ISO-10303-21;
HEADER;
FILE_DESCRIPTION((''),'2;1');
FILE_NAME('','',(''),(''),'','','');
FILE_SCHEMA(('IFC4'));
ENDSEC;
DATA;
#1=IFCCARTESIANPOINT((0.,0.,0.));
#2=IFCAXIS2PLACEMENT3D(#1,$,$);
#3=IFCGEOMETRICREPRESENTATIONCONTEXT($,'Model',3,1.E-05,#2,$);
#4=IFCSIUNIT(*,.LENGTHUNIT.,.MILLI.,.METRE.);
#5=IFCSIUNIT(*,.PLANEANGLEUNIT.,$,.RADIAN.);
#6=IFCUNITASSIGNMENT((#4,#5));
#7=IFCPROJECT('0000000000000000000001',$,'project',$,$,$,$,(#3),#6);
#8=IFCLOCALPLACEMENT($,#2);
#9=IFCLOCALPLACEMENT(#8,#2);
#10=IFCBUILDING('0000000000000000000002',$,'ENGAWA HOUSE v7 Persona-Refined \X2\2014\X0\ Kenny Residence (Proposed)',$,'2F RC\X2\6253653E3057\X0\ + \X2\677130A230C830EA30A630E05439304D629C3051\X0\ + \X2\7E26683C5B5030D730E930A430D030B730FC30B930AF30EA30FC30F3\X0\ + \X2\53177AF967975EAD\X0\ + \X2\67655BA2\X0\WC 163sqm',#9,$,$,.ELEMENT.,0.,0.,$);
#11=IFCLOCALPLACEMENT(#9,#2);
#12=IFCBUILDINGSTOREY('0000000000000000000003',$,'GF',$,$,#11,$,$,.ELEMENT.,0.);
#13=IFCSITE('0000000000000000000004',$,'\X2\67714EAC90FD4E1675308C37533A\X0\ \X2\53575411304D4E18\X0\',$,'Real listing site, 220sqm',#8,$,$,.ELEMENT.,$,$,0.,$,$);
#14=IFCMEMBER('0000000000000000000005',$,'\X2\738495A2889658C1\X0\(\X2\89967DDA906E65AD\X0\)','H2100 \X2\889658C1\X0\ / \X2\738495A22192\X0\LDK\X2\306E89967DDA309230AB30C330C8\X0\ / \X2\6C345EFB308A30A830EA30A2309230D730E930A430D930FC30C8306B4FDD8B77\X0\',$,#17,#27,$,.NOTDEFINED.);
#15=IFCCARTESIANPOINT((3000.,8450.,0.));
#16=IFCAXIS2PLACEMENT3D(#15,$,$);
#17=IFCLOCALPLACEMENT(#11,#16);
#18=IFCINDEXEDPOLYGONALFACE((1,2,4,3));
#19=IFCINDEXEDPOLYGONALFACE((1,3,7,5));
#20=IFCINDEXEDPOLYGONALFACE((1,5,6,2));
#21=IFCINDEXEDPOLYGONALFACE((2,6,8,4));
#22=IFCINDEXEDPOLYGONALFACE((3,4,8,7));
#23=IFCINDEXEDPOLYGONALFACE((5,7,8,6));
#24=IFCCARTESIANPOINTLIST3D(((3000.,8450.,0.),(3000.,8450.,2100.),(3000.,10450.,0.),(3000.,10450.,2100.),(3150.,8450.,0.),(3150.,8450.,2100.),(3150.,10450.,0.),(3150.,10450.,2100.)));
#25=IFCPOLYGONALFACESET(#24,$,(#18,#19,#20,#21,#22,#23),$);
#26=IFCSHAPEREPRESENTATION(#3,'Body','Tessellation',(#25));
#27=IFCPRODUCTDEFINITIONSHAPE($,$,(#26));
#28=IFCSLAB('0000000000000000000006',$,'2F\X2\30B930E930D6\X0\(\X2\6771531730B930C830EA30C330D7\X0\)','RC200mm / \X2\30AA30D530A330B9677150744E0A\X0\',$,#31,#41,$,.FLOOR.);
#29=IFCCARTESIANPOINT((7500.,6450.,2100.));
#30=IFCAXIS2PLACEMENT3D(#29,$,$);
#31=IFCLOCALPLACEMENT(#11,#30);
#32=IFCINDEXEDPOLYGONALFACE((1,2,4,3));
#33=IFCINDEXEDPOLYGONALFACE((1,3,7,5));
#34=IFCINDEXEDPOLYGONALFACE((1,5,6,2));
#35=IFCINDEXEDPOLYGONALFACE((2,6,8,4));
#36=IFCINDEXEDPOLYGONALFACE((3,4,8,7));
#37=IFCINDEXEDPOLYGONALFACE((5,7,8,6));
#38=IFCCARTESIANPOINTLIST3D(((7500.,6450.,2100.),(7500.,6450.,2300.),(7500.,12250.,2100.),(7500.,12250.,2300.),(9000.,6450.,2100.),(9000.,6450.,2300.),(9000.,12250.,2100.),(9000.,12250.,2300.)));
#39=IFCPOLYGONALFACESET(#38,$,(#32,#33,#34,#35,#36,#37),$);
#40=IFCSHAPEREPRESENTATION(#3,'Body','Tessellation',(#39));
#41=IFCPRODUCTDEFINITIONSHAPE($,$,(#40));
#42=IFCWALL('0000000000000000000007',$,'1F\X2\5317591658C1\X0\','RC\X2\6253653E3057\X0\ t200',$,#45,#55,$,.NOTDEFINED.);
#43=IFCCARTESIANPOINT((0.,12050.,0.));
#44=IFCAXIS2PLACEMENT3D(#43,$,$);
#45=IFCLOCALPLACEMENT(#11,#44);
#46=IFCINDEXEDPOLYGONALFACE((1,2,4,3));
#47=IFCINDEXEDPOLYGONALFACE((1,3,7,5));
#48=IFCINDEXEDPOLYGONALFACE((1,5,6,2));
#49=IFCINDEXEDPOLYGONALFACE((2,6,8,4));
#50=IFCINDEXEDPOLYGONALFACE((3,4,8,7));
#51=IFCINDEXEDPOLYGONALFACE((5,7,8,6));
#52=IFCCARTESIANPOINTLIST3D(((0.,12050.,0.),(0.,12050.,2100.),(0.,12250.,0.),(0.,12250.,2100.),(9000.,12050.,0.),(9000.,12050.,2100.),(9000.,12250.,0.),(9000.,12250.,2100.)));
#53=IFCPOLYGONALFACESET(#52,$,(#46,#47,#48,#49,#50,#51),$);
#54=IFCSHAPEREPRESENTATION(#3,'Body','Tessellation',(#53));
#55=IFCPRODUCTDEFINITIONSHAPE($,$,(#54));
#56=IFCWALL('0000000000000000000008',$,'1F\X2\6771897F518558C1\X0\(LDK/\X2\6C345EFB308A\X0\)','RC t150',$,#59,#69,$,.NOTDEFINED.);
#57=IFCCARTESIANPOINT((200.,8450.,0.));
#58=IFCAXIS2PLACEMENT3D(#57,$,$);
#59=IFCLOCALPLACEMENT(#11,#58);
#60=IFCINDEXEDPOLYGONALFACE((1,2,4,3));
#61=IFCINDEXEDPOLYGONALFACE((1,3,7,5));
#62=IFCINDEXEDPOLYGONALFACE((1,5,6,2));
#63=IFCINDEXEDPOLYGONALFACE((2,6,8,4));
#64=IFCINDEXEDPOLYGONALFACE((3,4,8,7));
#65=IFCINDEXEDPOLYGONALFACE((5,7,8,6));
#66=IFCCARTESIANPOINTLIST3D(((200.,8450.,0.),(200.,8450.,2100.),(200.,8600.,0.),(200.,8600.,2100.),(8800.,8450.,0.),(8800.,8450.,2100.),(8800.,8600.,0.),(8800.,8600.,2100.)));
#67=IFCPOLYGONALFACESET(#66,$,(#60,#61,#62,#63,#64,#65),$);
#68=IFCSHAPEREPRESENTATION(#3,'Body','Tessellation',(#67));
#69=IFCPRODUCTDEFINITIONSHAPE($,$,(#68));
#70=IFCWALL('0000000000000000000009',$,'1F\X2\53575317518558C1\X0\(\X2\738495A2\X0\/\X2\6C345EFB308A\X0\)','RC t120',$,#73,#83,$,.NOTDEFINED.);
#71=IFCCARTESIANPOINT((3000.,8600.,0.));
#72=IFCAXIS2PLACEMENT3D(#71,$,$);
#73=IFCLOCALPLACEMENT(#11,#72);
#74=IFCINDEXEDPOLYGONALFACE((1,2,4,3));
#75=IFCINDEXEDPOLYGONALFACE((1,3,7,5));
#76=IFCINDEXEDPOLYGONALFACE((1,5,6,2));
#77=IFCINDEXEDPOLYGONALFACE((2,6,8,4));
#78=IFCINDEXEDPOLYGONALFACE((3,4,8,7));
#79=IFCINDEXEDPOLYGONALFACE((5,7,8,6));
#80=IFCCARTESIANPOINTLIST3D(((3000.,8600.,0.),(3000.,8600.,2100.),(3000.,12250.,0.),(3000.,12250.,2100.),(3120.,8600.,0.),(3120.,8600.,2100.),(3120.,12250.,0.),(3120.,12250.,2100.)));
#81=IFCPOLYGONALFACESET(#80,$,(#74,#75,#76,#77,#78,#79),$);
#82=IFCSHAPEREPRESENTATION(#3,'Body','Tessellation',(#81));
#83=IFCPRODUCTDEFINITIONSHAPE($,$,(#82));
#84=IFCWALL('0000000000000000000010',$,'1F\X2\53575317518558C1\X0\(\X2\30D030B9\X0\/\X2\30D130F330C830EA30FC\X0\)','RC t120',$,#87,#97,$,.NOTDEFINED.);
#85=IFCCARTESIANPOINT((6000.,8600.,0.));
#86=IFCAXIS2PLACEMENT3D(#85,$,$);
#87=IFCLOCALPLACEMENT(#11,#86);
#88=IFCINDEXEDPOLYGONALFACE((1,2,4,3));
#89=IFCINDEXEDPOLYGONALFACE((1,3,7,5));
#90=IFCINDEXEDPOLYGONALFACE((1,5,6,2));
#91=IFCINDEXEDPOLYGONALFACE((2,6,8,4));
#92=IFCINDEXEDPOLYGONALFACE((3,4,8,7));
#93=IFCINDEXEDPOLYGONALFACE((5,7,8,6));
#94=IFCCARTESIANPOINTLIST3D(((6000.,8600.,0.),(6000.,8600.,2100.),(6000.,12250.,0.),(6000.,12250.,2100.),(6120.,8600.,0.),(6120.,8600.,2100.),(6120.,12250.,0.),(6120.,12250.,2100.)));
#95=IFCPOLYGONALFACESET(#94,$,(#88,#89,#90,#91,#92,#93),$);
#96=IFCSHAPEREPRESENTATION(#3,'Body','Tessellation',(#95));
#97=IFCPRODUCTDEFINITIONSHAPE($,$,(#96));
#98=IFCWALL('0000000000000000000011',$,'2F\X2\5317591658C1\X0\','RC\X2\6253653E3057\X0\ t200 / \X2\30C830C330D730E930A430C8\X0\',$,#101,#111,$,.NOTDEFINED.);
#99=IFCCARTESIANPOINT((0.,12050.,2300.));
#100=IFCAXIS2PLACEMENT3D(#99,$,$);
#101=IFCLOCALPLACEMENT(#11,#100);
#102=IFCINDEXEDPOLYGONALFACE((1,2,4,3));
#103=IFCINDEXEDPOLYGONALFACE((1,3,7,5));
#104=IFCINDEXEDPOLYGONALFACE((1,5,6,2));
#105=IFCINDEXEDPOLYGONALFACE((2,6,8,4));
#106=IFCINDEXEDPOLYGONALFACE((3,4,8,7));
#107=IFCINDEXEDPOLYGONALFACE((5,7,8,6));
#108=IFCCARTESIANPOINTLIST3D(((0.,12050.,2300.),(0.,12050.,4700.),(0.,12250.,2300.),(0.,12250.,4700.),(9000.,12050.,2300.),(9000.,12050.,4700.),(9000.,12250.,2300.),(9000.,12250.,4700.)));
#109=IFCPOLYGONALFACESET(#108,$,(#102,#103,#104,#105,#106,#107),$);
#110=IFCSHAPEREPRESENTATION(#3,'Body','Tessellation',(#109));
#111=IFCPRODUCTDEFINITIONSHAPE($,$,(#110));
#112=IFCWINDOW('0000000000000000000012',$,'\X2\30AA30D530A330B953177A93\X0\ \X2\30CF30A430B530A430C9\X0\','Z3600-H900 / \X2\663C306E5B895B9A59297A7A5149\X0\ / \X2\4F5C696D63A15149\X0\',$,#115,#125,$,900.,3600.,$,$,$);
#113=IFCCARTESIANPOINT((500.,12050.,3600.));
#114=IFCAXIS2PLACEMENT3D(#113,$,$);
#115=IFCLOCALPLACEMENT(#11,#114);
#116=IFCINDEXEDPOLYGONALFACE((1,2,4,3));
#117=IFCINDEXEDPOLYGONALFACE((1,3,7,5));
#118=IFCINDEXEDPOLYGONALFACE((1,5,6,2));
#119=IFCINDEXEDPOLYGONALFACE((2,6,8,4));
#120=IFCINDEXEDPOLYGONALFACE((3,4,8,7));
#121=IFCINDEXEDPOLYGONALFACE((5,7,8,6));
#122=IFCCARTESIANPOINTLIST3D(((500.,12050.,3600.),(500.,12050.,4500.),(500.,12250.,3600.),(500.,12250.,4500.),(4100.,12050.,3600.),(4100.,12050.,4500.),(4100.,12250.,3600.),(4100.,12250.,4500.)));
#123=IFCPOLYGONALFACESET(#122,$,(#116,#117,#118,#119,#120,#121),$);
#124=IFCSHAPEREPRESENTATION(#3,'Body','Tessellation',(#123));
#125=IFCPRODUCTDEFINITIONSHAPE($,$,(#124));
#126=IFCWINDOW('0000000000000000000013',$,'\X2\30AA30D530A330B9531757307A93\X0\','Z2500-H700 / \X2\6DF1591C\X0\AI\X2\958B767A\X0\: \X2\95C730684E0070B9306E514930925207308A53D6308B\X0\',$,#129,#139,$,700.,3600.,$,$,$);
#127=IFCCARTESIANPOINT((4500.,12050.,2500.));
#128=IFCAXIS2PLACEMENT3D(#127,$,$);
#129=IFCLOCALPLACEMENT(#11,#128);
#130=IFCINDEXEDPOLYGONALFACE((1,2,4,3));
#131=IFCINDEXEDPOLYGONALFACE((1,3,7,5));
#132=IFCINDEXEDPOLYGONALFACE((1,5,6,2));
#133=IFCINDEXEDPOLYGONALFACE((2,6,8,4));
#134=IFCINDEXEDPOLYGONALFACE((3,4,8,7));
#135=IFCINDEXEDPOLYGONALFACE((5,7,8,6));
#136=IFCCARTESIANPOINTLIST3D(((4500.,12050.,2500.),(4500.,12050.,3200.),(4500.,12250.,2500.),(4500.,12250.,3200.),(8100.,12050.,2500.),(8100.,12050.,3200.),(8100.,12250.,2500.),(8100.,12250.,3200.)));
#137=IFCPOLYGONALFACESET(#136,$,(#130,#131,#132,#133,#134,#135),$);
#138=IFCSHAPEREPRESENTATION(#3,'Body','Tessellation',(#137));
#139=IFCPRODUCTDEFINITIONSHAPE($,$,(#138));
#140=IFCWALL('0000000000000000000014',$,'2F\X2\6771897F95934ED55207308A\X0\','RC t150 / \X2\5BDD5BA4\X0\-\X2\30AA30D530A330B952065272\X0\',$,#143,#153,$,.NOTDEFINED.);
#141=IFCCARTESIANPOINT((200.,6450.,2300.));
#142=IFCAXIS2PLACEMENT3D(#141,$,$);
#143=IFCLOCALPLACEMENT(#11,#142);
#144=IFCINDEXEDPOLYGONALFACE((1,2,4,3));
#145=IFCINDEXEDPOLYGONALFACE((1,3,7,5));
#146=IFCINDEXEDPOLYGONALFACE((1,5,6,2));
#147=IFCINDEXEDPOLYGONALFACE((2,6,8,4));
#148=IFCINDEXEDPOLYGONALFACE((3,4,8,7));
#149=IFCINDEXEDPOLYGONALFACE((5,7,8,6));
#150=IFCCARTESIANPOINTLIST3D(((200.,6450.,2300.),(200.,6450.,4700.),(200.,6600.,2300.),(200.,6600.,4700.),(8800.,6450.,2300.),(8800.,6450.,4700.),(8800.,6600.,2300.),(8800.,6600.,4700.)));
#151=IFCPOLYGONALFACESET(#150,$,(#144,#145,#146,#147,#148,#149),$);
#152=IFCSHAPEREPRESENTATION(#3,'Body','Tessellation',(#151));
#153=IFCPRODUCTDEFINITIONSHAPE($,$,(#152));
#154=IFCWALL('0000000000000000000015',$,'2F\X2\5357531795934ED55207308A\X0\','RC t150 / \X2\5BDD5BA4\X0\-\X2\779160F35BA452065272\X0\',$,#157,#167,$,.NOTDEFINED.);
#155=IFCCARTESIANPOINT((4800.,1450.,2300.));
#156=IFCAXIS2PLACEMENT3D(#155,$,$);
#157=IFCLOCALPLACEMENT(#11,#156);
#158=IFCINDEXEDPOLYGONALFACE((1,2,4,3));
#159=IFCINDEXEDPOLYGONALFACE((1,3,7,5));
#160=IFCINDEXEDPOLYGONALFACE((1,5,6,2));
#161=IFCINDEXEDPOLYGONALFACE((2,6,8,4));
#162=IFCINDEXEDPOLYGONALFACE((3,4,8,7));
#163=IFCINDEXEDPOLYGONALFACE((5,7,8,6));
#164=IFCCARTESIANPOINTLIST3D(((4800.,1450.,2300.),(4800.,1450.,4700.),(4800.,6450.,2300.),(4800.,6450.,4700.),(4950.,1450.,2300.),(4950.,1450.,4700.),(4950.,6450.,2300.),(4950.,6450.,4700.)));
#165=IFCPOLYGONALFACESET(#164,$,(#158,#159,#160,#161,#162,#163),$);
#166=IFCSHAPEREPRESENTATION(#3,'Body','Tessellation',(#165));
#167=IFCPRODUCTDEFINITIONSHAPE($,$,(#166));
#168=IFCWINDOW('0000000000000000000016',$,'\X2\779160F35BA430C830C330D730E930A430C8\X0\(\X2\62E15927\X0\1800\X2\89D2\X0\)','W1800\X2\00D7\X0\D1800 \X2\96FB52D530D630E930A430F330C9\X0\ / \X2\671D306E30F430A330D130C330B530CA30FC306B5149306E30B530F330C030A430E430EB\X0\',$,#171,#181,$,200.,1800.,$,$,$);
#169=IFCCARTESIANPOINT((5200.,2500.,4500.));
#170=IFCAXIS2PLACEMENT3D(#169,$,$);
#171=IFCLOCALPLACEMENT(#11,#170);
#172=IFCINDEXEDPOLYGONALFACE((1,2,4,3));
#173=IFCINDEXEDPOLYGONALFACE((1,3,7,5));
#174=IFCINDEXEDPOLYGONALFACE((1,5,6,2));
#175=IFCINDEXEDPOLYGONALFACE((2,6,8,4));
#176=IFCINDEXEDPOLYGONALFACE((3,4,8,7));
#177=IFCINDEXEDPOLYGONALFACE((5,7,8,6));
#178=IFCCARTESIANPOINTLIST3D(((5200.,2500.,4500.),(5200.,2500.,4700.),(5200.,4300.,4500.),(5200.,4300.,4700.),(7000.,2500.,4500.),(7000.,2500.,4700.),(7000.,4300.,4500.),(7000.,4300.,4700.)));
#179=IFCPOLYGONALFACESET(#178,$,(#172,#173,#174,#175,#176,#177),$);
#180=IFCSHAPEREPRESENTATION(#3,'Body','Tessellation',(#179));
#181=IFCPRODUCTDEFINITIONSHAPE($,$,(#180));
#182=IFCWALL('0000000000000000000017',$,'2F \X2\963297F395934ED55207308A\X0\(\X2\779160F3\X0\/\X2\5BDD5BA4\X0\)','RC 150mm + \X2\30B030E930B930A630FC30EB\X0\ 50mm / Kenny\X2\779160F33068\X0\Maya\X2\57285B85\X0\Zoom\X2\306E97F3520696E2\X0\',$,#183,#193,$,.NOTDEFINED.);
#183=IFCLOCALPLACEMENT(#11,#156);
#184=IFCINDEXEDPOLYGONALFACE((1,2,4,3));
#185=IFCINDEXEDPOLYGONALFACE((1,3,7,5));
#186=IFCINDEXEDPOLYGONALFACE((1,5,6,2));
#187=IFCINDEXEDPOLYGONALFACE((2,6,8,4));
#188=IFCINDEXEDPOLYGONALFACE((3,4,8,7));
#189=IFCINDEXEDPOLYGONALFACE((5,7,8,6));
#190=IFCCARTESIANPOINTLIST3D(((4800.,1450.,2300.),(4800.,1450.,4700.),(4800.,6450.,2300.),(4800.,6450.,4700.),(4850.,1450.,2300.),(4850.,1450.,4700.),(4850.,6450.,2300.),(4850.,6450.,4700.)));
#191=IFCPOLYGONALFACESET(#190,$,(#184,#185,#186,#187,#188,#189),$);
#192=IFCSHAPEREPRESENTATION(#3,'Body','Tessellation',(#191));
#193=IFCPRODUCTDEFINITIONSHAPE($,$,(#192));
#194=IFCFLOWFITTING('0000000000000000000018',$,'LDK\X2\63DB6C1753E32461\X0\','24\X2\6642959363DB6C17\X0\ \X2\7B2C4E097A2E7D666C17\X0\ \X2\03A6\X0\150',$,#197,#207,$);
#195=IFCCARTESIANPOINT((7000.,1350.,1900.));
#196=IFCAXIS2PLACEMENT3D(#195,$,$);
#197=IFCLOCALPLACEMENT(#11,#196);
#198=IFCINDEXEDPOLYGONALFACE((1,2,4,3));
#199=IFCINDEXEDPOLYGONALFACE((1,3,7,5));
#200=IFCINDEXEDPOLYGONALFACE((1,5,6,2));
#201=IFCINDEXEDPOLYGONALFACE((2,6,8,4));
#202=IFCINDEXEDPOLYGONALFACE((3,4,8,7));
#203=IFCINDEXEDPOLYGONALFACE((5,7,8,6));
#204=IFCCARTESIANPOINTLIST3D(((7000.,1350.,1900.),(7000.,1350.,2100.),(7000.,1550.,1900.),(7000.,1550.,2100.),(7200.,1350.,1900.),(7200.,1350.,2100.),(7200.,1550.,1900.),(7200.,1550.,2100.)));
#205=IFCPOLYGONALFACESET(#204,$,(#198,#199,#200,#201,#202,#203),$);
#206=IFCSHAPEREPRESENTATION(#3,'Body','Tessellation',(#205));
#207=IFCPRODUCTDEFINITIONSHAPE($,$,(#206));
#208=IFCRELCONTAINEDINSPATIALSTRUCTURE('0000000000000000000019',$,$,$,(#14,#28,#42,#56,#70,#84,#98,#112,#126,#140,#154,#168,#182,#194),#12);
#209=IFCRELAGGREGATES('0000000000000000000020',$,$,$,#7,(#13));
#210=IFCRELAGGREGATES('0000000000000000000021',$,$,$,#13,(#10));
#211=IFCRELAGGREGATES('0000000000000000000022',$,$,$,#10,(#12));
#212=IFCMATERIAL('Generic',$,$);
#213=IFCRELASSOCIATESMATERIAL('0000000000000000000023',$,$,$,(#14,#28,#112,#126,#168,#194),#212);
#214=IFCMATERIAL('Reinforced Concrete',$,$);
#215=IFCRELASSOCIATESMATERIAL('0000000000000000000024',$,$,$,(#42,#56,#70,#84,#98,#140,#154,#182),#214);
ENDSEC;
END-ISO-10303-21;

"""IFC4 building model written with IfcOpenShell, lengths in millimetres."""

from ifc_helpers import new_model, si_unit, frame, frame_2d, origin, place, context, project, spatial, rectangle, extrude, material, element, fill, save


model = new_model("IFC4")

# Units and contexts
model_context = context("Model", 3, precision=1e-05, world=origin())
ifc_project = project(units=[si_unit("LENGTHUNIT", "METRE", prefix="MILLI"), si_unit("PLANEANGLEUNIT", "RADIAN")], contexts=[model_context])

# Site, building, storey
site_placement = place(None, origin())
site = spatial("IfcSite", under=ifc_project, at=site_placement, Name="東京都世田谷区 南向き丘", ObjectType="Real listing site, 220sqm", CompositionType="ELEMENT", RefElevation=0.0)
building_placement = place(site_placement, origin())
building = spatial("IfcBuilding", under=site, at=building_placement, Name="ENGAWA HOUSE v7 Persona-Refined — Kenny Residence (Proposed)", ObjectType="2F RC打放し + 東アトリウム吹き抜け + 縦格子プライバシースクリーン + 北竹林庭 + 来客WC 163sqm", CompositionType="ELEMENT", ElevationOfRefHeight=0.0, ElevationOfTerrain=0.0)
storey_placement = place(building_placement, origin())
storey = spatial("IfcBuildingStorey", under=building, at=storey_placement, Name="GF", CompositionType="ELEMENT", Elevation=0.0)

# Member
ifc_material_1 = material(Name="Generic")
member_placement = place(storey_placement, frame((3000.0, 8450.0, 0.0)))
element("IfcMember", 1, at=member_placement, inside=storey, material=ifc_material_1, Name="玄関袖壁(視線遮断)", Description="H2100 袖壁 / 玄関→LDKの視線をカット / 水廻りエリアをプライベートに保護", PredefinedType="NOTDEFINED", context=model_context, shape_type="SweptSolid", body=[
    extrude(rectangle(XDim=150.0, YDim=2000.0, at=frame_2d((75.0, 1000.0))), frame((3000.0, 8450.0, 0.0)), (0.0, 0.0, 1.0), 2100.0),
])

# Slab
slab_placement = place(storey_placement, frame((7500.0, 6450.0, 2100.0)))
element("IfcSlab", 2, at=slab_placement, inside=storey, material=ifc_material_1, Name="2Fスラブ(東北ストリップ)", Description="RC200mm / オフィス東側上", PredefinedType="FLOOR", context=model_context, shape_type="SweptSolid", body=[
    extrude(rectangle(XDim=1500.0, YDim=5800.0, at=frame_2d((750.0, 2900.0))), frame((7500.0, 6450.0, 2100.0)), (0.0, 0.0, 1.0), 200.0),
])

# Walls
ifc_material_2 = material(Name="Reinforced Concrete")
wall_1_placement = place(storey_placement, frame((0.0, 12050.0, 0.0)))
element("IfcWall", 3, at=wall_1_placement, inside=storey, material=ifc_material_2, Name="1F北外壁", Description="RC打放し t200", PredefinedType="NOTDEFINED", context=model_context, shape_type="SweptSolid", body=[
    extrude(rectangle(XDim=9000.0, YDim=200.0, at=frame_2d((4500.0, 100.0))), frame((0.0, 12050.0, 0.0)), (0.0, 0.0, 1.0), 2100.0),
])
wall_2_placement = place(storey_placement, frame((200.0, 8450.0, 0.0)))
element("IfcWall", 4, at=wall_2_placement, inside=storey, material=ifc_material_2, Name="1F東西内壁(LDK/水廻り)", Description="RC t150", PredefinedType="NOTDEFINED", context=model_context, shape_type="SweptSolid", body=[
    extrude(rectangle(XDim=8600.0, YDim=150.0, at=frame_2d((4300.0, 75.0))), frame((200.0, 8450.0, 0.0)), (0.0, 0.0, 1.0), 2100.0),
])
wall_3_placement = place(storey_placement, frame((3000.0, 8600.0, 0.0)))
element("IfcWall", 5, at=wall_3_placement, inside=storey, material=ifc_material_2, Name="1F南北内壁(玄関/水廻り)", Description="RC t120", PredefinedType="NOTDEFINED", context=model_context, shape_type="SweptSolid", body=[
    extrude(rectangle(XDim=120.0, YDim=3650.0, at=frame_2d((60.0, 1825.0))), frame((3000.0, 8600.0, 0.0)), (0.0, 0.0, 1.0), 2100.0),
])
wall_4_placement = place(storey_placement, frame((6000.0, 8600.0, 0.0)))
element("IfcWall", 6, at=wall_4_placement, inside=storey, material=ifc_material_2, Name="1F南北内壁(バス/パントリー)", Description="RC t120", PredefinedType="NOTDEFINED", context=model_context, shape_type="SweptSolid", body=[
    extrude(rectangle(XDim=120.0, YDim=3650.0, at=frame_2d((60.0, 1825.0))), frame((6000.0, 8600.0, 0.0)), (0.0, 0.0, 1.0), 2100.0),
])

# Wall, openings, windows
wall_5_placement = place(storey_placement, frame((0.0, 12050.0, 2300.0)))
wall_5 = element("IfcWall", 7, at=wall_5_placement, inside=storey, material=ifc_material_2, Name="2F北外壁", Description="RC打放し t200 / トップライト", PredefinedType="NOTDEFINED", context=model_context, shape_type="SweptSolid", body=[
    extrude(rectangle(XDim=9000.0, YDim=200.0, at=frame_2d((4500.0, 100.0))), frame((0.0, 12050.0, 2300.0)), (0.0, 0.0, 1.0), 2400.0),
])
opening_1_placement = place(storey_placement, frame((500.0, 12050.0, 3600.0)))
opening_1 = element("IfcOpeningElement", 8, at=opening_1_placement, cuts=wall_5, PredefinedType="NOTDEFINED", context=model_context, shape_type="SweptSolid", body=[
    extrude(rectangle(XDim=3600.0, YDim=200.0, at=frame_2d((1800.0, 100.0))), frame((500.0, 12050.0, 3600.0)), (0.0, 0.0, 1.0), 900.0),
])
opening_2_placement = place(storey_placement, frame((4500.0, 12050.0, 2500.0)))
opening_2 = element("IfcOpeningElement", 9, at=opening_2_placement, cuts=wall_5, PredefinedType="NOTDEFINED", context=model_context, shape_type="SweptSolid", body=[
    extrude(rectangle(XDim=3600.0, YDim=200.0, at=frame_2d((1800.0, 100.0))), frame((4500.0, 12050.0, 2500.0)), (0.0, 0.0, 1.0), 700.0),
])
window_1_placement = place(storey_placement, frame((500.0, 12050.0, 3600.0)))
window_1 = element("IfcWindow", 10, at=window_1_placement, inside=storey, material=ifc_material_1, Name="オフィス北窓 ハイサイド", Description="Z3600-H900 / 昼の安定天空光 / 作業採光", OverallHeight=900.0, OverallWidth=3600.0, context=model_context, shape_type="SweptSolid", body=[
    extrude(rectangle(XDim=3600.0, YDim=200.0, at=frame_2d((1800.0, 100.0))), frame((500.0, 12050.0, 3600.0)), (0.0, 0.0, 1.0), 900.0),
])
fill(opening_1, window_1)
window_2_placement = place(storey_placement, frame((4500.0, 12050.0, 2500.0)))
window_2 = element("IfcWindow", 11, at=window_2_placement, inside=storey, material=ifc_material_1, Name="オフィス北地窓", Description="Z2500-H700 / 深夜AI開発: 闇と一点の光を切り取る", OverallHeight=700.0, OverallWidth=3600.0, context=model_context, shape_type="SweptSolid", body=[
    extrude(rectangle(XDim=3600.0, YDim=200.0, at=frame_2d((1800.0, 100.0))), frame((4500.0, 12050.0, 2500.0)), (0.0, 0.0, 1.0), 700.0),
])
fill(opening_2, window_2)

# Walls
wall_6_placement = place(storey_placement, frame((200.0, 6450.0, 2300.0)))
element("IfcWall", 12, at=wall_6_placement, inside=storey, material=ifc_material_2, Name="2F東西間仕切り", Description="RC t150 / 寝室-オフィス分割", PredefinedType="NOTDEFINED", context=model_context, shape_type="SweptSolid", body=[
    extrude(rectangle(XDim=8600.0, YDim=150.0, at=frame_2d((4300.0, 75.0))), frame((200.0, 6450.0, 2300.0)), (0.0, 0.0, 1.0), 2400.0),
])
wall_7_placement = place(storey_placement, frame((4800.0, 1450.0, 2300.0)))
element("IfcWall", 13, at=wall_7_placement, inside=storey, material=ifc_material_2, Name="2F南北間仕切り", Description="RC t150 / 寝室-瞑想室分割", PredefinedType="NOTDEFINED", context=model_context, shape_type="SweptSolid", body=[
    extrude(rectangle(XDim=150.0, YDim=5000.0, at=frame_2d((75.0, 2500.0))), frame((4800.0, 1450.0, 2300.0)), (0.0, 0.0, 1.0), 2400.0),
])

# Window
window_3_placement = place(storey_placement, frame((5200.0, 2500.0, 4500.0)))
element("IfcWindow", 14, at=window_3_placement, inside=storey, material=ifc_material_1, Name="瞑想室トップライト(拡大1800角)", Description="W1800×D1800 電動ブラインド / 朝のヴィパッサナーに光のサンダイヤル", OverallHeight=200.0, OverallWidth=1800.0, context=model_context, shape_type="SweptSolid", body=[
    extrude(rectangle(XDim=1800.0, YDim=1800.0, at=frame_2d((900.0, 900.0))), frame((5200.0, 2500.0, 4500.0)), (0.0, 0.0, 1.0), 200.0),
])

# Wall
wall_8_placement = place(storey_placement, frame((4800.0, 1450.0, 2300.0)))
element("IfcWall", 15, at=wall_8_placement, inside=storey, material=ifc_material_2, Name="2F 防音間仕切り(瞑想/寝室)", Description="RC 150mm + グラスウール 50mm / Kenny瞑想とMaya在宅Zoomの音分離", PredefinedType="NOTDEFINED", context=model_context, shape_type="SweptSolid", body=[
    extrude(rectangle(XDim=50.0, YDim=5000.0, at=frame_2d((25.0, 2500.0))), frame((4800.0, 1450.0, 2300.0)), (0.0, 0.0, 1.0), 2400.0),
])

# Flow fitting
flow_fitting_1_placement = place(storey_placement, frame((7000.0, 1350.0, 1900.0)))
element("IfcFlowFitting", 16, at=flow_fitting_1_placement, inside=storey, material=ifc_material_1, Name="LDK換気口②", Description="24時間換気 第三種給気 Φ150", context=model_context, shape_type="SweptSolid", body=[
    extrude(rectangle(XDim=200.0, YDim=200.0, at=frame_2d((100.0, 100.0))), frame((7000.0, 1350.0, 1900.0)), (0.0, 0.0, 1.0), 200.0),
])

save(model, "model.ifc")
